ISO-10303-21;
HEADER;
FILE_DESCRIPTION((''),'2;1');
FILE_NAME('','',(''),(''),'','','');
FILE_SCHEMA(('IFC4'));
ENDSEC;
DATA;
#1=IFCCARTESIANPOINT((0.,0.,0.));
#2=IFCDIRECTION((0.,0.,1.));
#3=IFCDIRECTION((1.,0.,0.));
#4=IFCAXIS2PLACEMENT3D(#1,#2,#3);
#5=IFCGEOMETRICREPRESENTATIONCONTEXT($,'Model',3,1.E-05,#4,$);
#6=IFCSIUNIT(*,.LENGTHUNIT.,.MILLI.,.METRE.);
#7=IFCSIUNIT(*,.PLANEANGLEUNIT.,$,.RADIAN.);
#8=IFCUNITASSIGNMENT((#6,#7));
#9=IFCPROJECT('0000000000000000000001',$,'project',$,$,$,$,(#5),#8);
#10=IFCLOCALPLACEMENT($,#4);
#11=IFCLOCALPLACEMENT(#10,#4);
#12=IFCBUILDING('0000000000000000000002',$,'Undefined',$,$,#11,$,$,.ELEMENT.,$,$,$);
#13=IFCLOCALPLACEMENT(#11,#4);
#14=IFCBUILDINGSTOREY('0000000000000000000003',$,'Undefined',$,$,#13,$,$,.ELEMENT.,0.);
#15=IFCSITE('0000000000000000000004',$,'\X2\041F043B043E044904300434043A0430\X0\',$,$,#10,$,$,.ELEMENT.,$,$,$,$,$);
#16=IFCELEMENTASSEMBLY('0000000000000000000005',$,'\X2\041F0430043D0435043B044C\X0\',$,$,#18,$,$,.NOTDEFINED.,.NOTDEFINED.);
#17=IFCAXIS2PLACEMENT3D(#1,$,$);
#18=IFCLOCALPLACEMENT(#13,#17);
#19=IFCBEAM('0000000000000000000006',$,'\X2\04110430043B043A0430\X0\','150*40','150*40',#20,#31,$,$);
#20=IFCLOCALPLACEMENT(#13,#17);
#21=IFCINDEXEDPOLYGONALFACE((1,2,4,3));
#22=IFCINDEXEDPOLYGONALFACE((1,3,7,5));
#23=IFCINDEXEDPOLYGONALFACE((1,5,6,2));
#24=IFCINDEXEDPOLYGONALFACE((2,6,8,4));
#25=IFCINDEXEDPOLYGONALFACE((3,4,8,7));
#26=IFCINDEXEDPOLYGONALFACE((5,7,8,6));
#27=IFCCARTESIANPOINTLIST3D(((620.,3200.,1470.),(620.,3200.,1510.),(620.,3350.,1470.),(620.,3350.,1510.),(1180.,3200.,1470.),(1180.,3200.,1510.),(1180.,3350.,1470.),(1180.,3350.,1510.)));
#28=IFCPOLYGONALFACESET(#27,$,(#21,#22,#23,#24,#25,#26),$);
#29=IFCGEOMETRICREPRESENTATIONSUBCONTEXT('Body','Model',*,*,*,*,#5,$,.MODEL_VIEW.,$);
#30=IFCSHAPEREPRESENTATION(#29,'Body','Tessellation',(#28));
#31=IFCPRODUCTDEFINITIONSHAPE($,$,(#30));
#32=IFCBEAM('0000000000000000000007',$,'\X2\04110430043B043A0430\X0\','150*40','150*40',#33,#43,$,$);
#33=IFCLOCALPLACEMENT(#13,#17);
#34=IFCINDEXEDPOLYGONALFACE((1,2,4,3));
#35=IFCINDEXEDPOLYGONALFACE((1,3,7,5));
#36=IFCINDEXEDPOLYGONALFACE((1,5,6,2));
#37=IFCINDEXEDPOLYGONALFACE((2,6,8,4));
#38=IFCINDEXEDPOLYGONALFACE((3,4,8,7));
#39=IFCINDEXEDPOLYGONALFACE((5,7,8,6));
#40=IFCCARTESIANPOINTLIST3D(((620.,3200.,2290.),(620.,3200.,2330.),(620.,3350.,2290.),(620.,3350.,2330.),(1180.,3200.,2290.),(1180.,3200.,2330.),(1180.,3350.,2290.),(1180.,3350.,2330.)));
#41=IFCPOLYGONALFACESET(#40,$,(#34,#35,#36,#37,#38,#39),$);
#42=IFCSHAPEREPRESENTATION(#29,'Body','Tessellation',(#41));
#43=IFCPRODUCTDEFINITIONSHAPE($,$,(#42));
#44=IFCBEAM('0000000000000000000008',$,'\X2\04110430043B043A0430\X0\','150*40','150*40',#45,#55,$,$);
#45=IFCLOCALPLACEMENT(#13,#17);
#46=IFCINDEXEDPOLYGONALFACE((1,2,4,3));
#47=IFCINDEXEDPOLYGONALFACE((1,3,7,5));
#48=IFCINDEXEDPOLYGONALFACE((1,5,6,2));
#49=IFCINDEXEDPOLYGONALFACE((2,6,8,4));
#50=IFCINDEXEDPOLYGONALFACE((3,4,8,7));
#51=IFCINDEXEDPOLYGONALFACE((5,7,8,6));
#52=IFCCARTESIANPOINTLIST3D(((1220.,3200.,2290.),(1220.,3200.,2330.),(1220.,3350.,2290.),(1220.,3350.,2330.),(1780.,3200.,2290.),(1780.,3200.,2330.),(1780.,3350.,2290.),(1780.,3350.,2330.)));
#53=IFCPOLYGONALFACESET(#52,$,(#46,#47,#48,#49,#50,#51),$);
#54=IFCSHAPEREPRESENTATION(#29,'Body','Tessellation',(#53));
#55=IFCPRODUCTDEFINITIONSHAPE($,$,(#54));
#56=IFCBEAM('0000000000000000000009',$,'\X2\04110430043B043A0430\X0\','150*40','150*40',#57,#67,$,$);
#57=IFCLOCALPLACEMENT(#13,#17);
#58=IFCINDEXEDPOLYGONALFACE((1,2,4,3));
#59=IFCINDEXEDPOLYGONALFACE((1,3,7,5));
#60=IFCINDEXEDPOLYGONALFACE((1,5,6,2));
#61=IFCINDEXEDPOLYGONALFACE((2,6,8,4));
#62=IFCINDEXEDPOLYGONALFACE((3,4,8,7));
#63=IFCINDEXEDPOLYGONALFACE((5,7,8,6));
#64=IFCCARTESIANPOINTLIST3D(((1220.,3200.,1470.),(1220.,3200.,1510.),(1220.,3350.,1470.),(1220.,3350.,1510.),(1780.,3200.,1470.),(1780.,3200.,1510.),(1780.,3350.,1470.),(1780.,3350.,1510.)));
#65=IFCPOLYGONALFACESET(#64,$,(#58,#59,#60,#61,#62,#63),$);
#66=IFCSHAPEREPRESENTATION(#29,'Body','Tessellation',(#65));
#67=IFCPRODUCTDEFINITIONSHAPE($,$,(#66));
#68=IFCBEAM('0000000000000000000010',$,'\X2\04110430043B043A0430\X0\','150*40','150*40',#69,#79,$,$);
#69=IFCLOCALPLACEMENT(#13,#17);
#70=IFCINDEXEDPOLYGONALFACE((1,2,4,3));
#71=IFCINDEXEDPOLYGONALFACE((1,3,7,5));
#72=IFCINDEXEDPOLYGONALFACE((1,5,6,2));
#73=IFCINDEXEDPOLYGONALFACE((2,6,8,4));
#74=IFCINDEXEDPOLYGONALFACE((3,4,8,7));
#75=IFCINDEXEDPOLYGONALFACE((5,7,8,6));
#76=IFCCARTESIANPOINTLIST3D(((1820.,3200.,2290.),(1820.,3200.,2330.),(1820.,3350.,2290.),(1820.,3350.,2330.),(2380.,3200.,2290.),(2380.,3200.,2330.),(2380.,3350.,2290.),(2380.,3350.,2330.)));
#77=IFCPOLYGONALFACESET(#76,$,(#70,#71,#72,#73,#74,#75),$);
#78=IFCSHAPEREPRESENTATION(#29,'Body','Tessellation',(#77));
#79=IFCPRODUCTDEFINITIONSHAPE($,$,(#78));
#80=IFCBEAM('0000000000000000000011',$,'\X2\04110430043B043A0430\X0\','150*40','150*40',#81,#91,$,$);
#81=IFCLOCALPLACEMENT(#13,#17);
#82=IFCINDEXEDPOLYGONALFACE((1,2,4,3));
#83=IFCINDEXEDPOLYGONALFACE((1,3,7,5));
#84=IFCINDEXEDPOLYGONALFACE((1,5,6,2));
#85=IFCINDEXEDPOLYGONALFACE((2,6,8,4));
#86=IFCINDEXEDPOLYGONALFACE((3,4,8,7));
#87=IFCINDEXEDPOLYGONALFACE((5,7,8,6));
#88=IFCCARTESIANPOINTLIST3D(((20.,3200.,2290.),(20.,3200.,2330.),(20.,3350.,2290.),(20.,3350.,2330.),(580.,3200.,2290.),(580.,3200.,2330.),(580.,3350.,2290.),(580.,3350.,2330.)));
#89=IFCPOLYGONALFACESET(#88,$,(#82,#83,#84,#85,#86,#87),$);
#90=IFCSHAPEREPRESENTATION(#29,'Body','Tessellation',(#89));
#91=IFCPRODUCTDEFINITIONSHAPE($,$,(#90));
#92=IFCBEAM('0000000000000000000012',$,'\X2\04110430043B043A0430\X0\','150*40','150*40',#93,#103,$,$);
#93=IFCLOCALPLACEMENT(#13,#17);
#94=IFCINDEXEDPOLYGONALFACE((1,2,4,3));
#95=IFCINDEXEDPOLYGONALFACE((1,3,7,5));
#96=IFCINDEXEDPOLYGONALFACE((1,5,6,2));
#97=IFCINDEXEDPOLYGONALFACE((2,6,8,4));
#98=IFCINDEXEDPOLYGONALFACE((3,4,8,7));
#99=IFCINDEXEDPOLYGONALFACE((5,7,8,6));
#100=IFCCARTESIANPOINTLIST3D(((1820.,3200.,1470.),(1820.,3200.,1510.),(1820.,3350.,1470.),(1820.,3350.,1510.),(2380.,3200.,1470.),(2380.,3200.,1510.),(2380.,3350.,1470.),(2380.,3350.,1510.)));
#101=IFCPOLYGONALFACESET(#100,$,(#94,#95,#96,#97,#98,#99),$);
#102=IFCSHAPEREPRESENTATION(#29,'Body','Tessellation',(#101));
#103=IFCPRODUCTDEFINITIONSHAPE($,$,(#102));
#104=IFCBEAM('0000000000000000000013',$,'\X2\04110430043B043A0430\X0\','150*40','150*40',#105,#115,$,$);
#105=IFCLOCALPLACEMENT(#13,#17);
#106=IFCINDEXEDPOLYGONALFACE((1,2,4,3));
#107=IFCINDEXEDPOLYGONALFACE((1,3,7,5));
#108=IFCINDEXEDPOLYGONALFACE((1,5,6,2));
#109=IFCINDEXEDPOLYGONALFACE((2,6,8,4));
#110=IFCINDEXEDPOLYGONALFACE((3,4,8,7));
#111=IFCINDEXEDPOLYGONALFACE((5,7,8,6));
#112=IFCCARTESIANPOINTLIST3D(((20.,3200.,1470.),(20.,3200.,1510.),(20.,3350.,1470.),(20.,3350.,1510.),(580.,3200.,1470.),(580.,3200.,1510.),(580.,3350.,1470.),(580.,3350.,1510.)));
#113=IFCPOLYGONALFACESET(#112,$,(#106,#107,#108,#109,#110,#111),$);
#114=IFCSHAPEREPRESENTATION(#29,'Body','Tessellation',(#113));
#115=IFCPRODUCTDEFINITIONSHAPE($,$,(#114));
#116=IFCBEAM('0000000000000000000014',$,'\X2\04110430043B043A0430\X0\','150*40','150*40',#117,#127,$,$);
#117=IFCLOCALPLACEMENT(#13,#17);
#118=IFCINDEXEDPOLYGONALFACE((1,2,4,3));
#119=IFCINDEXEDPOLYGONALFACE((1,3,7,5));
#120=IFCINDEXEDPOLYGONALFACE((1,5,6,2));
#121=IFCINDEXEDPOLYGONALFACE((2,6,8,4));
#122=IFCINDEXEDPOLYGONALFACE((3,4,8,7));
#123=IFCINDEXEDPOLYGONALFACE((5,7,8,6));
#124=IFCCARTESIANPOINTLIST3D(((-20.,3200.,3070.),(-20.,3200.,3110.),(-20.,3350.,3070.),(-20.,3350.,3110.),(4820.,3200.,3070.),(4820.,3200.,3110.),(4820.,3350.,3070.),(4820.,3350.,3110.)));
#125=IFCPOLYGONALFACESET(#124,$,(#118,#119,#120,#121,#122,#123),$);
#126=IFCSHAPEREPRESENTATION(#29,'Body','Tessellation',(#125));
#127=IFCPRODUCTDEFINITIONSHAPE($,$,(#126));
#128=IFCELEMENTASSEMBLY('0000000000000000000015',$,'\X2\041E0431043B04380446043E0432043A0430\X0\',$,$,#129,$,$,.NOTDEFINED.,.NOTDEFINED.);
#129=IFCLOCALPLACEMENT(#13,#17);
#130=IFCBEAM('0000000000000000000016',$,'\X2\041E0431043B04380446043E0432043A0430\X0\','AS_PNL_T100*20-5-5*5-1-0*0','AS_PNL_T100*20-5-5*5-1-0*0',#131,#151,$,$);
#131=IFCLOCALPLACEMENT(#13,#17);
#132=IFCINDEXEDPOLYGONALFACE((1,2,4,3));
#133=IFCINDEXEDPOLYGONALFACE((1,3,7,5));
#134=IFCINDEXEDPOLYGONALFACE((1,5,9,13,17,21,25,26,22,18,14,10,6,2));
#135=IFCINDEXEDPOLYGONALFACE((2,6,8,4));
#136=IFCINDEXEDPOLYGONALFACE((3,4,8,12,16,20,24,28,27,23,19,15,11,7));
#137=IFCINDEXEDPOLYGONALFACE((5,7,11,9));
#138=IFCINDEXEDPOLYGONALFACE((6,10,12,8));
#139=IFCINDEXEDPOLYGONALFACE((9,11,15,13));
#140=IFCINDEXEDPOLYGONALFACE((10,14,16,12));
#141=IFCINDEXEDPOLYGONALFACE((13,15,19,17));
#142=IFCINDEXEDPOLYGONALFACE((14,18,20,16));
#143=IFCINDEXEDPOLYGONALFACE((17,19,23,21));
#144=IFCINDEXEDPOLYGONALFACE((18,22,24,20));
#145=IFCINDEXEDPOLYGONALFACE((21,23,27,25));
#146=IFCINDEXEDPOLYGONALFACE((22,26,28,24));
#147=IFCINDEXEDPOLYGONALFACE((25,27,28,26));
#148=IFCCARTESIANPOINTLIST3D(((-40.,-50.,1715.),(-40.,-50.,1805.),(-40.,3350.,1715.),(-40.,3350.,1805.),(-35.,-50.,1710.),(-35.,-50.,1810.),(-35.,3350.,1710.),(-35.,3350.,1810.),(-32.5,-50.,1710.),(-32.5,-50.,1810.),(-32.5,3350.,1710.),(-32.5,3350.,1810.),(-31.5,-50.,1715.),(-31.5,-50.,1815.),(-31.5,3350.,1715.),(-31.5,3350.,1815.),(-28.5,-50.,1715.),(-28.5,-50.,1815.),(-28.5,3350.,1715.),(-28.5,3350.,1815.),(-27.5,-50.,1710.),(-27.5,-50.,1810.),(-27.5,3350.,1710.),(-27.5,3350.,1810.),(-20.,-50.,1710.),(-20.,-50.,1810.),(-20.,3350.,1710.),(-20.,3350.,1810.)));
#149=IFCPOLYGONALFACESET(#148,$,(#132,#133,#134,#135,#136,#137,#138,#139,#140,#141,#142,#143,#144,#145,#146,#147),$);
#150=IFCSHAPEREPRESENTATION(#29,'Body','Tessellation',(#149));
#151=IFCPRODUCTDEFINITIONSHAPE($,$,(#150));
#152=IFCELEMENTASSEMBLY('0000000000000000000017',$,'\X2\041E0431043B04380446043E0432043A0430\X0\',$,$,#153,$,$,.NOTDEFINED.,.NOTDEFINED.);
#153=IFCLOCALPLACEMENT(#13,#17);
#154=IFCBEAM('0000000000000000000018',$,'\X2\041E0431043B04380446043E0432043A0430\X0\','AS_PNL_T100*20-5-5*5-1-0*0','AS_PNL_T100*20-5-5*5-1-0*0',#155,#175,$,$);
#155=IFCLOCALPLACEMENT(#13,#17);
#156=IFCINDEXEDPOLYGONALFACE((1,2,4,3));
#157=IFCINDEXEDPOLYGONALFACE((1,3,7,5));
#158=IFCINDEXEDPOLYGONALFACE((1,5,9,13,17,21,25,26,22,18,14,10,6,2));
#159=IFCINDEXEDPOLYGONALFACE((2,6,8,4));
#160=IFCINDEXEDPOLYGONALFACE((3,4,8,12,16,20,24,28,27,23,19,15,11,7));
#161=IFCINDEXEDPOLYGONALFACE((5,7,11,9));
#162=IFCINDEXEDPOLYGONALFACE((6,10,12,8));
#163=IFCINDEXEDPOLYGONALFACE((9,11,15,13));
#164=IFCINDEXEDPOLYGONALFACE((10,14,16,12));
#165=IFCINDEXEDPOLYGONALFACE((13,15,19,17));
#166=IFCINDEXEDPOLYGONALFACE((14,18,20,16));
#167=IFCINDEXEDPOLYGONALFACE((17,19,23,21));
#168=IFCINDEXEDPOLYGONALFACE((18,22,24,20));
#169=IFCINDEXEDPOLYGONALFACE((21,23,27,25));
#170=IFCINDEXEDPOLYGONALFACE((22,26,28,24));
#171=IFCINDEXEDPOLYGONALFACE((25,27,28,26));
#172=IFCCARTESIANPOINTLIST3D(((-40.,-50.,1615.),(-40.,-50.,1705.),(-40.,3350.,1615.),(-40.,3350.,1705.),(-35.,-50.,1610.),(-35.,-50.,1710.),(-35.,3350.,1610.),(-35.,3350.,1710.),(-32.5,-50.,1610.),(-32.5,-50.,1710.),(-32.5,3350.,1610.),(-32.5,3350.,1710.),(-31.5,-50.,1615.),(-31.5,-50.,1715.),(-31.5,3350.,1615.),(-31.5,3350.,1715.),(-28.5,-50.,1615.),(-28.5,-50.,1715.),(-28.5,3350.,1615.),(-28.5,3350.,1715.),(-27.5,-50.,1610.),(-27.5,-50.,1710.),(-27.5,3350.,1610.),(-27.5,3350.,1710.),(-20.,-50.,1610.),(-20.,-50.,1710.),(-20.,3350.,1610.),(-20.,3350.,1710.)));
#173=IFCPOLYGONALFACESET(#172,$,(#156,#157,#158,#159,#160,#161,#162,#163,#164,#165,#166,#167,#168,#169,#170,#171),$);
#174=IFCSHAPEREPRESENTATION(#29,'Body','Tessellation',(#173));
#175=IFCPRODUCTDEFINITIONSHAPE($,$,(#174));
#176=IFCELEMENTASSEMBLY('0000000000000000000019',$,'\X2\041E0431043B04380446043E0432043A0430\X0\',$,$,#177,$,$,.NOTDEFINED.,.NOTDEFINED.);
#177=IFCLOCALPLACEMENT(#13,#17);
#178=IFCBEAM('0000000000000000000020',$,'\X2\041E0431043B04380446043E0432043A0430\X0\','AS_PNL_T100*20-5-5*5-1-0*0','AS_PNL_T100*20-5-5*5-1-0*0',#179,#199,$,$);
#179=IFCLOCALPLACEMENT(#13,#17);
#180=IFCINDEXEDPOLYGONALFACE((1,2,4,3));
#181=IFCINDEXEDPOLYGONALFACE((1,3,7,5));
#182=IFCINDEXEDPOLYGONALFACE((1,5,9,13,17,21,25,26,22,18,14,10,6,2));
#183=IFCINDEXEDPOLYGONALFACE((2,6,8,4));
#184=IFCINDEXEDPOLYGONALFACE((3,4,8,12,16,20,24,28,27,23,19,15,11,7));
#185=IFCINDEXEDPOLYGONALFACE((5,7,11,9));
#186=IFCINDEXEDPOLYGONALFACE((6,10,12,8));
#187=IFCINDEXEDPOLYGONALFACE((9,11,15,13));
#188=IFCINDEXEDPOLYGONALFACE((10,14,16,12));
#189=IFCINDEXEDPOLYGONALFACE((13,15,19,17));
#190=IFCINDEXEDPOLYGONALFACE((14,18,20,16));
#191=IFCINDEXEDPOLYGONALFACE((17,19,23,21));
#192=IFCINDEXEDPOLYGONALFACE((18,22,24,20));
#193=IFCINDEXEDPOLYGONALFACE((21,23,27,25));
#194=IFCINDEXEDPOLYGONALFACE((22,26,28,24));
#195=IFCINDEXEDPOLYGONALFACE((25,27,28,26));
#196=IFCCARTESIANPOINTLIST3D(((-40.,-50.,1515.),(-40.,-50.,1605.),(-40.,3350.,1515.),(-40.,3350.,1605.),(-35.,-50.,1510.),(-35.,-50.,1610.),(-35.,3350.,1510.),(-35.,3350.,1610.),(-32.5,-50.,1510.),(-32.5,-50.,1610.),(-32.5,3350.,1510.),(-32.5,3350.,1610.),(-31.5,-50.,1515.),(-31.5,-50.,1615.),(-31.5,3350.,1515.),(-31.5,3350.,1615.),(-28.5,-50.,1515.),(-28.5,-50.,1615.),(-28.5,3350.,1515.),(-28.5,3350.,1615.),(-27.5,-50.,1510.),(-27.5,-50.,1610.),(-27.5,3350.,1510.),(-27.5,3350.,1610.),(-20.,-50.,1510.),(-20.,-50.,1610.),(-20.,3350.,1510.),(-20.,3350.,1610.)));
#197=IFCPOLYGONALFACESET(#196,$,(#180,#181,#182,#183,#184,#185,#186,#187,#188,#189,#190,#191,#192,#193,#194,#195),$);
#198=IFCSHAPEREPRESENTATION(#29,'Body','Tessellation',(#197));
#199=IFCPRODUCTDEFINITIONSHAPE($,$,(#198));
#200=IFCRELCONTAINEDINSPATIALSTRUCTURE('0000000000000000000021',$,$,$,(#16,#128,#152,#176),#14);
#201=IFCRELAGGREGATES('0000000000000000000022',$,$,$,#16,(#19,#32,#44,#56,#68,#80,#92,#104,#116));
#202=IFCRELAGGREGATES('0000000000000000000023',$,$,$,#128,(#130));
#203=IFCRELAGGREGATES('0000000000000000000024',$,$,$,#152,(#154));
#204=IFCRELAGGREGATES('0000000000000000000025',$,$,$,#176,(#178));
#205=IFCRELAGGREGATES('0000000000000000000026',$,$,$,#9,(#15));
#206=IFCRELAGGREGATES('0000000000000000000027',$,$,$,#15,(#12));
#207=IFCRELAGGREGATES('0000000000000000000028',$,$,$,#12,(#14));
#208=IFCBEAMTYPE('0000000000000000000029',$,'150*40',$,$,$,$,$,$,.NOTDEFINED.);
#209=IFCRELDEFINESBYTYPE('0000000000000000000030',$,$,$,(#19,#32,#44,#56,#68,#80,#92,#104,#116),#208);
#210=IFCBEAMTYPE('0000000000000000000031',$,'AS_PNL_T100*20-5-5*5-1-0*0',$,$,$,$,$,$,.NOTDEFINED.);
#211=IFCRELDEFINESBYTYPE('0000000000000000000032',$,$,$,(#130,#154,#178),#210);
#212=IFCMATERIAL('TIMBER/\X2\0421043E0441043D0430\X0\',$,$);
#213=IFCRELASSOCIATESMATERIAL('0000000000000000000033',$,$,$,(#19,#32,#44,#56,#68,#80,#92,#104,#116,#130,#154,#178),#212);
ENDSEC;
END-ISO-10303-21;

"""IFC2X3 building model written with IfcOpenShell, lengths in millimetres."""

from ifc_helpers import new_model, si_unit, frame, origin_with_axes, origin_2d_with_axis, place, context, subcontext, project, spatial, polyline, rectangle, outline, extrude, material, type_object, element, aggregate, save


model = new_model("IFC2X3")

# Units and contexts
model_context = context("Model", 3, precision=1e-05, world=origin_with_axes())
body_context = subcontext(model_context, "Body", "Model", "MODEL_VIEW")
ifc_project = project(units=[si_unit("LENGTHUNIT", "METRE", prefix="MILLI"), si_unit("PLANEANGLEUNIT", "RADIAN")], contexts=[model_context])

# Site, building, storey
site_placement = place(None, origin_with_axes())
site = spatial("IfcSite", under=ifc_project, at=site_placement, Name="Площадка", CompositionType="ELEMENT")
building_placement = place(site_placement, origin_with_axes())
building = spatial("IfcBuilding", under=site, at=building_placement, Name="Undefined", CompositionType="ELEMENT")
storey_placement = place(building_placement, origin_with_axes())
storey = spatial("IfcBuildingStorey", under=building, at=storey_placement, Name="Undefined", CompositionType="ELEMENT", Elevation=0.0)

# Element assembly, beams
assembly_1_placement = place(storey_placement, origin_with_axes())
assembly_1 = element("IfcElementAssembly", 1, at=assembly_1_placement, inside=storey, Name="Панель", AssemblyPlace="NOTDEFINED", PredefinedType="NOTDEFINED")
ifc_material = material(Name="TIMBER/Сосна")
beam_type_1 = type_object("IfcBeamType", Name="150*40", PredefinedType="NOTDEFINED")
beam_1_placement = place(assembly_1_placement, frame((620.0, 3275.0, 1490.0), z_axis=(0.0, 1.0, 0.0), x_axis=(1.0, 0.0, 0.0)))
beam_1 = element("IfcBeam", 2, at=beam_1_placement, type_object=beam_type_1, material=ifc_material, Name="Балка", Description="150*40", ObjectType="150*40", context=body_context, shape_type="SweptSolid", body=[
    extrude(rectangle(XDim=40.0, YDim=150.0, at=origin_2d_with_axis()), frame((560.0, 0.0, 0.0), z_axis=(-1.0, 0.0, 0.0), x_axis=(0.0, -1.0, 0.0)), (0.0, 0.0, 1.0), 560.0),
])
beam_2_placement = place(assembly_1_placement, frame((620.0, 3275.0, 2310.0), z_axis=(0.0, 1.0, 0.0), x_axis=(1.0, 0.0, 0.0)))
beam_2 = element("IfcBeam", 3, at=beam_2_placement, type_object=beam_type_1, material=ifc_material, Name="Балка", Description="150*40", ObjectType="150*40", context=body_context, shape_type="SweptSolid", body=[
    extrude(rectangle(XDim=40.0, YDim=150.0, at=origin_2d_with_axis()), frame((560.0, 0.0, 0.0), z_axis=(-1.0, 0.0, 0.0), x_axis=(0.0, -1.0, 0.0)), (0.0, 0.0, 1.0), 560.0),
])
beam_3_placement = place(assembly_1_placement, frame((1220.0, 3275.0, 2310.0), z_axis=(0.0, 1.0, 0.0), x_axis=(1.0, 0.0, 0.0)))
beam_3 = element("IfcBeam", 4, at=beam_3_placement, type_object=beam_type_1, material=ifc_material, Name="Балка", Description="150*40", ObjectType="150*40", context=body_context, shape_type="SweptSolid", body=[
    extrude(rectangle(XDim=40.0, YDim=150.0, at=origin_2d_with_axis()), frame((560.0, 0.0, 0.0), z_axis=(-1.0, 0.0, 0.0), x_axis=(0.0, -1.0, 0.0)), (0.0, 0.0, 1.0), 560.0),
])
beam_4_placement = place(assembly_1_placement, frame((1220.0, 3275.0, 1490.0), z_axis=(0.0, 1.0, 0.0), x_axis=(1.0, 0.0, 0.0)))
beam_4 = element("IfcBeam", 5, at=beam_4_placement, type_object=beam_type_1, material=ifc_material, Name="Балка", Description="150*40", ObjectType="150*40", context=body_context, shape_type="SweptSolid", body=[
    extrude(rectangle(XDim=40.0, YDim=150.0, at=origin_2d_with_axis()), frame((560.0, 0.0, 0.0), z_axis=(-1.0, 0.0, 0.0), x_axis=(0.0, -1.0, 0.0)), (0.0, 0.0, 1.0), 560.0),
])

# Beams
beam_5_placement = place(assembly_1_placement, frame((1820.0, 3275.0, 2310.0), z_axis=(0.0, 1.0, 0.0), x_axis=(1.0, 0.0, 0.0)))
beam_5 = element("IfcBeam", 6, at=beam_5_placement, type_object=beam_type_1, material=ifc_material, Name="Балка", Description="150*40", ObjectType="150*40", context=body_context, shape_type="SweptSolid", body=[
    extrude(rectangle(XDim=40.0, YDim=150.0, at=origin_2d_with_axis()), frame((560.0, 0.0, 0.0), z_axis=(-1.0, 0.0, 0.0), x_axis=(0.0, -1.0, 0.0)), (0.0, 0.0, 1.0), 560.0),
])
beam_6_placement = place(assembly_1_placement, frame((20.0, 3275.0, 2310.0), z_axis=(0.0, 1.0, 0.0), x_axis=(1.0, 0.0, 0.0)))
beam_6 = element("IfcBeam", 7, at=beam_6_placement, type_object=beam_type_1, material=ifc_material, Name="Балка", Description="150*40", ObjectType="150*40", context=body_context, shape_type="SweptSolid", body=[
    extrude(rectangle(XDim=40.0, YDim=150.0, at=origin_2d_with_axis()), frame((560.0, 0.0, 0.0), z_axis=(-1.0, 0.0, 0.0), x_axis=(0.0, -1.0, 0.0)), (0.0, 0.0, 1.0), 560.0),
])
beam_7_placement = place(assembly_1_placement, frame((1820.0, 3275.0, 1490.0), z_axis=(0.0, 1.0, 0.0), x_axis=(1.0, 0.0, 0.0)))
beam_7 = element("IfcBeam", 8, at=beam_7_placement, type_object=beam_type_1, material=ifc_material, Name="Балка", Description="150*40", ObjectType="150*40", context=body_context, shape_type="SweptSolid", body=[
    extrude(rectangle(XDim=40.0, YDim=150.0, at=origin_2d_with_axis()), frame((560.0, 0.0, 0.0), z_axis=(-1.0, 0.0, 0.0), x_axis=(0.0, -1.0, 0.0)), (0.0, 0.0, 1.0), 560.0),
])
beam_8_placement = place(assembly_1_placement, frame((20.0, 3275.0, 1490.0), z_axis=(0.0, 1.0, 0.0), x_axis=(1.0, 0.0, 0.0)))
beam_8 = element("IfcBeam", 9, at=beam_8_placement, type_object=beam_type_1, material=ifc_material, Name="Балка", Description="150*40", ObjectType="150*40", context=body_context, shape_type="SweptSolid", body=[
    extrude(rectangle(XDim=40.0, YDim=150.0, at=origin_2d_with_axis()), frame((560.0, 0.0, 0.0), z_axis=(-1.0, 0.0, 0.0), x_axis=(0.0, -1.0, 0.0)), (0.0, 0.0, 1.0), 560.0),
])
beam_9_placement = place(assembly_1_placement, frame((-20.0, 3275.0, 3090.0), z_axis=(0.0, 1.0, 0.0), x_axis=(1.0, 0.0, 0.0)))
beam_9 = element("IfcBeam", 10, at=beam_9_placement, type_object=beam_type_1, material=ifc_material, Name="Балка", Description="150*40", ObjectType="150*40", context=body_context, shape_type="SweptSolid", body=[
    extrude(rectangle(XDim=40.0, YDim=150.0, at=origin_2d_with_axis()), frame((4840.0, 0.0, 0.0), z_axis=(-1.0, 0.0, 0.0), x_axis=(0.0, -1.0, 0.0)), (0.0, 0.0, 1.0), 4840.0),
])
aggregate(assembly_1, [beam_1, beam_2, beam_3, beam_4, beam_5, beam_6, beam_7, beam_8, beam_9])

# Element assemblies, beams
assembly_2_placement = place(storey_placement, origin_with_axes())
assembly_2 = element("IfcElementAssembly", 11, at=assembly_2_placement, inside=storey, Name="Облицовка", AssemblyPlace="NOTDEFINED", PredefinedType="NOTDEFINED")
beam_type_2 = type_object("IfcBeamType", Name="AS_PNL_T100*20-5-5*5-1-0*0", PredefinedType="NOTDEFINED")
beam_10_placement = place(assembly_2_placement, frame((-30.0, 3350.0, 1760.0), z_axis=(0.0, 0.0, 1.0), x_axis=(0.0, -1.0, 0.0)))
beam_10 = element("IfcBeam", 12, at=beam_10_placement, type_object=beam_type_2, material=ifc_material, Name="Облицовка", Description="AS_PNL_T100*20-5-5*5-1-0*0", ObjectType="AS_PNL_T100*20-5-5*5-1-0*0", context=body_context, shape_type="SweptSolid", body=[
    extrude(outline(polyline([(-2.5, -50.0), (-10.0, -50.0), (-10.0, 50.0), (-2.5, 50.0), (-1.5, 55.0), (1.5, 55.0), (2.5, 50.0), (5.0, 50.0), (10.0, 45.0), (10.0, -45.0), (5.0, -50.0), (2.5, -50.0), (1.5, -45.0), (-1.5, -45.0), (-2.5, -50.0)])), frame((3400.0, 0.0, 0.0), z_axis=(-1.0, 0.0, 0.0), x_axis=(0.0, -1.0, 0.0)), (0.0, 0.0, 1.0), 3400.0),
])
aggregate(assembly_2, [beam_10])
assembly_3_placement = place(storey_placement, origin_with_axes())
assembly_3 = element("IfcElementAssembly", 13, at=assembly_3_placement, inside=storey, Name="Облицовка", AssemblyPlace="NOTDEFINED", PredefinedType="NOTDEFINED")
beam_11_placement = place(assembly_3_placement, frame((-30.0, 3350.0, 1660.0), z_axis=(0.0, 0.0, 1.0), x_axis=(0.0, -1.0, 0.0)))
beam_11 = element("IfcBeam", 14, at=beam_11_placement, type_object=beam_type_2, material=ifc_material, Name="Облицовка", Description="AS_PNL_T100*20-5-5*5-1-0*0", ObjectType="AS_PNL_T100*20-5-5*5-1-0*0", context=body_context, shape_type="SweptSolid", body=[
    extrude(outline(polyline([(-2.5, -50.0), (-10.0, -50.0), (-10.0, 50.0), (-2.5, 50.0), (-1.5, 55.0), (1.5, 55.0), (2.5, 50.0), (5.0, 50.0), (10.0, 45.0), (10.0, -45.0), (5.0, -50.0), (2.5, -50.0), (1.5, -45.0), (-1.5, -45.0), (-2.5, -50.0)])), frame((3400.0, 0.0, 0.0), z_axis=(-1.0, 0.0, 0.0), x_axis=(0.0, -1.0, 0.0)), (0.0, 0.0, 1.0), 3400.0),
])
aggregate(assembly_3, [beam_11])
assembly_4_placement = place(storey_placement, origin_with_axes())
assembly_4 = element("IfcElementAssembly", 15, at=assembly_4_placement, inside=storey, Name="Облицовка", AssemblyPlace="NOTDEFINED", PredefinedType="NOTDEFINED")
beam_12_placement = place(assembly_4_placement, frame((-30.0, 3350.0, 1560.0), z_axis=(0.0, 0.0, 1.0), x_axis=(0.0, -1.0, 0.0)))
beam_12 = element("IfcBeam", 16, at=beam_12_placement, type_object=beam_type_2, material=ifc_material, Name="Облицовка", Description="AS_PNL_T100*20-5-5*5-1-0*0", ObjectType="AS_PNL_T100*20-5-5*5-1-0*0", context=body_context, shape_type="SweptSolid", body=[
    extrude(outline(polyline([(-2.5, -50.0), (-10.0, -50.0), (-10.0, 50.0), (-2.5, 50.0), (-1.5, 55.0), (1.5, 55.0), (2.5, 50.0), (5.0, 50.0), (10.0, 45.0), (10.0, -45.0), (5.0, -50.0), (2.5, -50.0), (1.5, -45.0), (-1.5, -45.0), (-2.5, -50.0)])), frame((3400.0, 0.0, 0.0), z_axis=(-1.0, 0.0, 0.0), x_axis=(0.0, -1.0, 0.0)), (0.0, 0.0, 1.0), 3400.0),
])
aggregate(assembly_4, [beam_12])

save(model, "model.ifc")
